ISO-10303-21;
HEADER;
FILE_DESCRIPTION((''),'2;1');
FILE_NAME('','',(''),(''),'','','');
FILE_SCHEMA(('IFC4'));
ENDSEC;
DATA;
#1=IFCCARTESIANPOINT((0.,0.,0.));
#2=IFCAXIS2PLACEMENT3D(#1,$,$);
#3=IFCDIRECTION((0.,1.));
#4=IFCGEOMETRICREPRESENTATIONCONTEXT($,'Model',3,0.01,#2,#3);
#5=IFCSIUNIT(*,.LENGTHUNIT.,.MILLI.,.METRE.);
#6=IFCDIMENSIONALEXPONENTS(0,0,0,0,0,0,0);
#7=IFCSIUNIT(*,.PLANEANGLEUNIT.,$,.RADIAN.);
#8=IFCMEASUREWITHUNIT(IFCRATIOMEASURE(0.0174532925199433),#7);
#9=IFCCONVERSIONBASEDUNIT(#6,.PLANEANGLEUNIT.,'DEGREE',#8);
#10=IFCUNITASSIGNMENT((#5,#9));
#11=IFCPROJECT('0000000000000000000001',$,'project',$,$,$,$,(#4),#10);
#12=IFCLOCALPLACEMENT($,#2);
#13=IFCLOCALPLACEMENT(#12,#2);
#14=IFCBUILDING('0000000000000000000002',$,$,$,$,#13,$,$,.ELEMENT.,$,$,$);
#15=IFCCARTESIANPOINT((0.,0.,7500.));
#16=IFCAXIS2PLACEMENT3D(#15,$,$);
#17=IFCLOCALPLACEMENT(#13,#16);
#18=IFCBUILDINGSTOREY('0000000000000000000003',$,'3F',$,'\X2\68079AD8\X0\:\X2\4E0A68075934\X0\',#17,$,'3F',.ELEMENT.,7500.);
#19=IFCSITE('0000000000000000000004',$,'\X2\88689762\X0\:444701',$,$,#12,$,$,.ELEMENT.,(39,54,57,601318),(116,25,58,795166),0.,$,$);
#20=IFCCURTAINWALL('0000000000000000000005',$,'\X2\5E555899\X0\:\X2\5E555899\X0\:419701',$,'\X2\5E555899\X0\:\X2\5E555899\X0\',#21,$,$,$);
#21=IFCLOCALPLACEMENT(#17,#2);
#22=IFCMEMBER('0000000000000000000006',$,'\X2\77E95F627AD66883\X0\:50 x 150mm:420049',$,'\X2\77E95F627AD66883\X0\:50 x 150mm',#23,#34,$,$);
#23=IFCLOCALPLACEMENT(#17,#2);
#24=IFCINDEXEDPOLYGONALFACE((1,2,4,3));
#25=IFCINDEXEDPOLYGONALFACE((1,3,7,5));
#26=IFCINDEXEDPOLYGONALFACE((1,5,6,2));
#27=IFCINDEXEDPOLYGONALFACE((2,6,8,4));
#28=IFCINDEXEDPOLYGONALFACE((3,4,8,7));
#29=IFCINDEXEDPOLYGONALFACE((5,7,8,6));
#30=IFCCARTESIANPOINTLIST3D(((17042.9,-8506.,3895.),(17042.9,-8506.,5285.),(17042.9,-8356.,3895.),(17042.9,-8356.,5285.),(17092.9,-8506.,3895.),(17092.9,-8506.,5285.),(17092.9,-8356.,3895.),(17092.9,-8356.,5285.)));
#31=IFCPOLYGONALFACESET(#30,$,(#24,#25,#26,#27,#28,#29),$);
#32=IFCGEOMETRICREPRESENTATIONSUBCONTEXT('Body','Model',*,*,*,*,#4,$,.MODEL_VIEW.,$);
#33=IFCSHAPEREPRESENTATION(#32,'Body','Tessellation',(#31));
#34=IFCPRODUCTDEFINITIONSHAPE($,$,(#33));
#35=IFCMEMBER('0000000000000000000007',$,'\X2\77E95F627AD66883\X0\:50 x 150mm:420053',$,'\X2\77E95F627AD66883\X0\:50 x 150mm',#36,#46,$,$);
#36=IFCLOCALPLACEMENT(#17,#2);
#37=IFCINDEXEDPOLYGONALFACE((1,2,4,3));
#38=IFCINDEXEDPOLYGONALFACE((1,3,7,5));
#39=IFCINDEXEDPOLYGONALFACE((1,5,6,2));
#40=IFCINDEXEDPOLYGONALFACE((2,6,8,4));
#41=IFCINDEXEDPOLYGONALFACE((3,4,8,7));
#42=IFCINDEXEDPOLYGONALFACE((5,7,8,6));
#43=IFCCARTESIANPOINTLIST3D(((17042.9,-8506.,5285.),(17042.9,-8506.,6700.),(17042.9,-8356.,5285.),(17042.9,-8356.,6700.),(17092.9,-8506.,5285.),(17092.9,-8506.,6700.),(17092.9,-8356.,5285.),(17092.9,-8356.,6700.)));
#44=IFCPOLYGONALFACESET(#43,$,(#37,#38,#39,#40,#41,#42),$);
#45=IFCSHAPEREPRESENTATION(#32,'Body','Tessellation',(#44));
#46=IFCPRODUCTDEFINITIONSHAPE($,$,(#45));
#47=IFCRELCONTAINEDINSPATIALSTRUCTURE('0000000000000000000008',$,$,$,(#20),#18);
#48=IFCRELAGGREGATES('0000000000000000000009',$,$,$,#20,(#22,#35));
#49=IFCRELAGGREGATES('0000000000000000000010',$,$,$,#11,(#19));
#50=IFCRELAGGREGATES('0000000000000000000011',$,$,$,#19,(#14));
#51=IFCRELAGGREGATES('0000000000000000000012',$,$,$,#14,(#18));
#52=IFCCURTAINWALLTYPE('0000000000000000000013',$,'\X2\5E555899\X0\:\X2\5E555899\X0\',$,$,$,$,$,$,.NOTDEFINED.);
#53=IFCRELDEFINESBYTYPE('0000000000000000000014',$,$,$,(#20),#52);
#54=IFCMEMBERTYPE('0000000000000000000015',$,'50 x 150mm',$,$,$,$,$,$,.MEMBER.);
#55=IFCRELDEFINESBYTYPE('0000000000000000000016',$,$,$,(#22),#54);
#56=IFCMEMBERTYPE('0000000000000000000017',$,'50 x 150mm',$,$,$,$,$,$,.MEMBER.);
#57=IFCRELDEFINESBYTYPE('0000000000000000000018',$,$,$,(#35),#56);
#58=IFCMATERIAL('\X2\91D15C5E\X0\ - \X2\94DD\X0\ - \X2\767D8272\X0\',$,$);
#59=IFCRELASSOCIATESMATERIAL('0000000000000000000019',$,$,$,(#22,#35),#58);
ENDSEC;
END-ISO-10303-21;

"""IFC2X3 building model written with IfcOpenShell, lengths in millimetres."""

from ifc_helpers import new_model, entity, si_unit, converted_unit, direction, frame, origin, origin_2d_with_axis, place, context, subcontext, project, spatial, rectangle, extrude, source, transform, mapped, material, type_object, type_shapes, element, aggregate, save


model = new_model("IFC2X3")

# Units and contexts
model_context = context("Model", 3, precision=0.01, world=origin(), true_north=direction((0.0, 1.0)))
body_context = subcontext(model_context, "Body", "Model", "MODEL_VIEW")
ifc_project = project(units=[si_unit("LENGTHUNIT", "METRE", prefix="MILLI"), converted_unit("PLANEANGLEUNIT", "DEGREE", entity("IfcRatioMeasure", 0.0174532925199433), si_unit("PLANEANGLEUNIT", "RADIAN"), dimensions=[0, 0, 0, 0, 0, 0, 0])], contexts=[model_context])

# Site, building, storey
site_placement = place(None, origin())
site = spatial("IfcSite", under=ifc_project, at=site_placement, Name="表面:444701", CompositionType="ELEMENT", RefLatitude=(39, 54, 57, 601318), RefLongitude=(116, 25, 58, 795166), RefElevation=0.0)
building_placement = place(site_placement, origin())
building = spatial("IfcBuilding", under=site, at=building_placement, CompositionType="ELEMENT")
storey_placement = place(building_placement, frame((0.0, 0.0, 7500.0)))
storey = spatial("IfcBuildingStorey", under=building, at=storey_placement, Name="3F", ObjectType="标高:上标头", LongName="3F", CompositionType="ELEMENT", Elevation=7500.0)

# Curtain wall, members
curtain_wall_type = type_object("IfcCurtainWallType", Name="幕墙:幕墙", PredefinedType="NOTDEFINED")
curtain_wall_placement = place(storey_placement, frame((0.0, 0.0, -7500.0)))
curtain_wall = element("IfcCurtainWall", 1, at=curtain_wall_placement, inside=storey, type_object=curtain_wall_type, Name="幕墙:幕墙:419701", ObjectType="幕墙:幕墙")
ifc_material_1 = material(Name="金属 - 铝 - 白色")
member_type_1 = type_object("IfcMemberType", Name="50 x 150mm", PredefinedType="MEMBER")
shared_shape_1 = source(origin(), body_context, "Body", "SweptSolid", [
    extrude(rectangle(XDim=150.0, YDim=50.0, at=origin_2d_with_axis()), frame((0.0, 0.0, -1390.0), z_axis=(0.0, 0.0, 1.0), x_axis=(0.0, -1.0, 0.0)), (0.0, 0.0, 1.0), 1390.0),
])
type_shapes(member_type_1, [shared_shape_1])
member_1_placement = place(storey_placement, frame((17067.9, -8431.0, 3895.0), z_axis=(0.0, 0.0, -1.0), x_axis=(-1.0, 0.0, 0.0)))
member_1 = element("IfcMember", 2, at=member_1_placement, type_object=member_type_1, material=ifc_material_1, Name="矩形竖梃:50 x 150mm:420049", ObjectType="矩形竖梃:50 x 150mm", context=body_context, shape_type="MappedRepresentation", body=[
    mapped(shared_shape_1, transform((0.0, 0.0, 0.0), scale=1.0)),
])
member_type_2 = type_object("IfcMemberType", Name="50 x 150mm", PredefinedType="MEMBER")
shared_shape_2 = source(origin(), body_context, "Body", "SweptSolid", [
    extrude(rectangle(XDim=150.0, YDim=50.0, at=origin_2d_with_axis()), frame((0.0, 0.0, -1415.0), z_axis=(0.0, 0.0, 1.0), x_axis=(0.0, -1.0, 0.0)), (0.0, 0.0, 1.0), 1415.0),
])
type_shapes(member_type_2, [shared_shape_2])
member_2_placement = place(storey_placement, frame((17067.9, -8431.0, 5285.0), z_axis=(0.0, 0.0, -1.0), x_axis=(-1.0, 0.0, 0.0)))
member_2 = element("IfcMember", 3, at=member_2_placement, type_object=member_type_2, material=ifc_material_1, Name="矩形竖梃:50 x 150mm:420053", ObjectType="矩形竖梃:50 x 150mm", context=body_context, shape_type="MappedRepresentation", body=[
    mapped(shared_shape_2, transform((0.0, 0.0, 0.0), scale=1.0)),
])
aggregate(curtain_wall, [member_1, member_2])

save(model, "model.ifc")
